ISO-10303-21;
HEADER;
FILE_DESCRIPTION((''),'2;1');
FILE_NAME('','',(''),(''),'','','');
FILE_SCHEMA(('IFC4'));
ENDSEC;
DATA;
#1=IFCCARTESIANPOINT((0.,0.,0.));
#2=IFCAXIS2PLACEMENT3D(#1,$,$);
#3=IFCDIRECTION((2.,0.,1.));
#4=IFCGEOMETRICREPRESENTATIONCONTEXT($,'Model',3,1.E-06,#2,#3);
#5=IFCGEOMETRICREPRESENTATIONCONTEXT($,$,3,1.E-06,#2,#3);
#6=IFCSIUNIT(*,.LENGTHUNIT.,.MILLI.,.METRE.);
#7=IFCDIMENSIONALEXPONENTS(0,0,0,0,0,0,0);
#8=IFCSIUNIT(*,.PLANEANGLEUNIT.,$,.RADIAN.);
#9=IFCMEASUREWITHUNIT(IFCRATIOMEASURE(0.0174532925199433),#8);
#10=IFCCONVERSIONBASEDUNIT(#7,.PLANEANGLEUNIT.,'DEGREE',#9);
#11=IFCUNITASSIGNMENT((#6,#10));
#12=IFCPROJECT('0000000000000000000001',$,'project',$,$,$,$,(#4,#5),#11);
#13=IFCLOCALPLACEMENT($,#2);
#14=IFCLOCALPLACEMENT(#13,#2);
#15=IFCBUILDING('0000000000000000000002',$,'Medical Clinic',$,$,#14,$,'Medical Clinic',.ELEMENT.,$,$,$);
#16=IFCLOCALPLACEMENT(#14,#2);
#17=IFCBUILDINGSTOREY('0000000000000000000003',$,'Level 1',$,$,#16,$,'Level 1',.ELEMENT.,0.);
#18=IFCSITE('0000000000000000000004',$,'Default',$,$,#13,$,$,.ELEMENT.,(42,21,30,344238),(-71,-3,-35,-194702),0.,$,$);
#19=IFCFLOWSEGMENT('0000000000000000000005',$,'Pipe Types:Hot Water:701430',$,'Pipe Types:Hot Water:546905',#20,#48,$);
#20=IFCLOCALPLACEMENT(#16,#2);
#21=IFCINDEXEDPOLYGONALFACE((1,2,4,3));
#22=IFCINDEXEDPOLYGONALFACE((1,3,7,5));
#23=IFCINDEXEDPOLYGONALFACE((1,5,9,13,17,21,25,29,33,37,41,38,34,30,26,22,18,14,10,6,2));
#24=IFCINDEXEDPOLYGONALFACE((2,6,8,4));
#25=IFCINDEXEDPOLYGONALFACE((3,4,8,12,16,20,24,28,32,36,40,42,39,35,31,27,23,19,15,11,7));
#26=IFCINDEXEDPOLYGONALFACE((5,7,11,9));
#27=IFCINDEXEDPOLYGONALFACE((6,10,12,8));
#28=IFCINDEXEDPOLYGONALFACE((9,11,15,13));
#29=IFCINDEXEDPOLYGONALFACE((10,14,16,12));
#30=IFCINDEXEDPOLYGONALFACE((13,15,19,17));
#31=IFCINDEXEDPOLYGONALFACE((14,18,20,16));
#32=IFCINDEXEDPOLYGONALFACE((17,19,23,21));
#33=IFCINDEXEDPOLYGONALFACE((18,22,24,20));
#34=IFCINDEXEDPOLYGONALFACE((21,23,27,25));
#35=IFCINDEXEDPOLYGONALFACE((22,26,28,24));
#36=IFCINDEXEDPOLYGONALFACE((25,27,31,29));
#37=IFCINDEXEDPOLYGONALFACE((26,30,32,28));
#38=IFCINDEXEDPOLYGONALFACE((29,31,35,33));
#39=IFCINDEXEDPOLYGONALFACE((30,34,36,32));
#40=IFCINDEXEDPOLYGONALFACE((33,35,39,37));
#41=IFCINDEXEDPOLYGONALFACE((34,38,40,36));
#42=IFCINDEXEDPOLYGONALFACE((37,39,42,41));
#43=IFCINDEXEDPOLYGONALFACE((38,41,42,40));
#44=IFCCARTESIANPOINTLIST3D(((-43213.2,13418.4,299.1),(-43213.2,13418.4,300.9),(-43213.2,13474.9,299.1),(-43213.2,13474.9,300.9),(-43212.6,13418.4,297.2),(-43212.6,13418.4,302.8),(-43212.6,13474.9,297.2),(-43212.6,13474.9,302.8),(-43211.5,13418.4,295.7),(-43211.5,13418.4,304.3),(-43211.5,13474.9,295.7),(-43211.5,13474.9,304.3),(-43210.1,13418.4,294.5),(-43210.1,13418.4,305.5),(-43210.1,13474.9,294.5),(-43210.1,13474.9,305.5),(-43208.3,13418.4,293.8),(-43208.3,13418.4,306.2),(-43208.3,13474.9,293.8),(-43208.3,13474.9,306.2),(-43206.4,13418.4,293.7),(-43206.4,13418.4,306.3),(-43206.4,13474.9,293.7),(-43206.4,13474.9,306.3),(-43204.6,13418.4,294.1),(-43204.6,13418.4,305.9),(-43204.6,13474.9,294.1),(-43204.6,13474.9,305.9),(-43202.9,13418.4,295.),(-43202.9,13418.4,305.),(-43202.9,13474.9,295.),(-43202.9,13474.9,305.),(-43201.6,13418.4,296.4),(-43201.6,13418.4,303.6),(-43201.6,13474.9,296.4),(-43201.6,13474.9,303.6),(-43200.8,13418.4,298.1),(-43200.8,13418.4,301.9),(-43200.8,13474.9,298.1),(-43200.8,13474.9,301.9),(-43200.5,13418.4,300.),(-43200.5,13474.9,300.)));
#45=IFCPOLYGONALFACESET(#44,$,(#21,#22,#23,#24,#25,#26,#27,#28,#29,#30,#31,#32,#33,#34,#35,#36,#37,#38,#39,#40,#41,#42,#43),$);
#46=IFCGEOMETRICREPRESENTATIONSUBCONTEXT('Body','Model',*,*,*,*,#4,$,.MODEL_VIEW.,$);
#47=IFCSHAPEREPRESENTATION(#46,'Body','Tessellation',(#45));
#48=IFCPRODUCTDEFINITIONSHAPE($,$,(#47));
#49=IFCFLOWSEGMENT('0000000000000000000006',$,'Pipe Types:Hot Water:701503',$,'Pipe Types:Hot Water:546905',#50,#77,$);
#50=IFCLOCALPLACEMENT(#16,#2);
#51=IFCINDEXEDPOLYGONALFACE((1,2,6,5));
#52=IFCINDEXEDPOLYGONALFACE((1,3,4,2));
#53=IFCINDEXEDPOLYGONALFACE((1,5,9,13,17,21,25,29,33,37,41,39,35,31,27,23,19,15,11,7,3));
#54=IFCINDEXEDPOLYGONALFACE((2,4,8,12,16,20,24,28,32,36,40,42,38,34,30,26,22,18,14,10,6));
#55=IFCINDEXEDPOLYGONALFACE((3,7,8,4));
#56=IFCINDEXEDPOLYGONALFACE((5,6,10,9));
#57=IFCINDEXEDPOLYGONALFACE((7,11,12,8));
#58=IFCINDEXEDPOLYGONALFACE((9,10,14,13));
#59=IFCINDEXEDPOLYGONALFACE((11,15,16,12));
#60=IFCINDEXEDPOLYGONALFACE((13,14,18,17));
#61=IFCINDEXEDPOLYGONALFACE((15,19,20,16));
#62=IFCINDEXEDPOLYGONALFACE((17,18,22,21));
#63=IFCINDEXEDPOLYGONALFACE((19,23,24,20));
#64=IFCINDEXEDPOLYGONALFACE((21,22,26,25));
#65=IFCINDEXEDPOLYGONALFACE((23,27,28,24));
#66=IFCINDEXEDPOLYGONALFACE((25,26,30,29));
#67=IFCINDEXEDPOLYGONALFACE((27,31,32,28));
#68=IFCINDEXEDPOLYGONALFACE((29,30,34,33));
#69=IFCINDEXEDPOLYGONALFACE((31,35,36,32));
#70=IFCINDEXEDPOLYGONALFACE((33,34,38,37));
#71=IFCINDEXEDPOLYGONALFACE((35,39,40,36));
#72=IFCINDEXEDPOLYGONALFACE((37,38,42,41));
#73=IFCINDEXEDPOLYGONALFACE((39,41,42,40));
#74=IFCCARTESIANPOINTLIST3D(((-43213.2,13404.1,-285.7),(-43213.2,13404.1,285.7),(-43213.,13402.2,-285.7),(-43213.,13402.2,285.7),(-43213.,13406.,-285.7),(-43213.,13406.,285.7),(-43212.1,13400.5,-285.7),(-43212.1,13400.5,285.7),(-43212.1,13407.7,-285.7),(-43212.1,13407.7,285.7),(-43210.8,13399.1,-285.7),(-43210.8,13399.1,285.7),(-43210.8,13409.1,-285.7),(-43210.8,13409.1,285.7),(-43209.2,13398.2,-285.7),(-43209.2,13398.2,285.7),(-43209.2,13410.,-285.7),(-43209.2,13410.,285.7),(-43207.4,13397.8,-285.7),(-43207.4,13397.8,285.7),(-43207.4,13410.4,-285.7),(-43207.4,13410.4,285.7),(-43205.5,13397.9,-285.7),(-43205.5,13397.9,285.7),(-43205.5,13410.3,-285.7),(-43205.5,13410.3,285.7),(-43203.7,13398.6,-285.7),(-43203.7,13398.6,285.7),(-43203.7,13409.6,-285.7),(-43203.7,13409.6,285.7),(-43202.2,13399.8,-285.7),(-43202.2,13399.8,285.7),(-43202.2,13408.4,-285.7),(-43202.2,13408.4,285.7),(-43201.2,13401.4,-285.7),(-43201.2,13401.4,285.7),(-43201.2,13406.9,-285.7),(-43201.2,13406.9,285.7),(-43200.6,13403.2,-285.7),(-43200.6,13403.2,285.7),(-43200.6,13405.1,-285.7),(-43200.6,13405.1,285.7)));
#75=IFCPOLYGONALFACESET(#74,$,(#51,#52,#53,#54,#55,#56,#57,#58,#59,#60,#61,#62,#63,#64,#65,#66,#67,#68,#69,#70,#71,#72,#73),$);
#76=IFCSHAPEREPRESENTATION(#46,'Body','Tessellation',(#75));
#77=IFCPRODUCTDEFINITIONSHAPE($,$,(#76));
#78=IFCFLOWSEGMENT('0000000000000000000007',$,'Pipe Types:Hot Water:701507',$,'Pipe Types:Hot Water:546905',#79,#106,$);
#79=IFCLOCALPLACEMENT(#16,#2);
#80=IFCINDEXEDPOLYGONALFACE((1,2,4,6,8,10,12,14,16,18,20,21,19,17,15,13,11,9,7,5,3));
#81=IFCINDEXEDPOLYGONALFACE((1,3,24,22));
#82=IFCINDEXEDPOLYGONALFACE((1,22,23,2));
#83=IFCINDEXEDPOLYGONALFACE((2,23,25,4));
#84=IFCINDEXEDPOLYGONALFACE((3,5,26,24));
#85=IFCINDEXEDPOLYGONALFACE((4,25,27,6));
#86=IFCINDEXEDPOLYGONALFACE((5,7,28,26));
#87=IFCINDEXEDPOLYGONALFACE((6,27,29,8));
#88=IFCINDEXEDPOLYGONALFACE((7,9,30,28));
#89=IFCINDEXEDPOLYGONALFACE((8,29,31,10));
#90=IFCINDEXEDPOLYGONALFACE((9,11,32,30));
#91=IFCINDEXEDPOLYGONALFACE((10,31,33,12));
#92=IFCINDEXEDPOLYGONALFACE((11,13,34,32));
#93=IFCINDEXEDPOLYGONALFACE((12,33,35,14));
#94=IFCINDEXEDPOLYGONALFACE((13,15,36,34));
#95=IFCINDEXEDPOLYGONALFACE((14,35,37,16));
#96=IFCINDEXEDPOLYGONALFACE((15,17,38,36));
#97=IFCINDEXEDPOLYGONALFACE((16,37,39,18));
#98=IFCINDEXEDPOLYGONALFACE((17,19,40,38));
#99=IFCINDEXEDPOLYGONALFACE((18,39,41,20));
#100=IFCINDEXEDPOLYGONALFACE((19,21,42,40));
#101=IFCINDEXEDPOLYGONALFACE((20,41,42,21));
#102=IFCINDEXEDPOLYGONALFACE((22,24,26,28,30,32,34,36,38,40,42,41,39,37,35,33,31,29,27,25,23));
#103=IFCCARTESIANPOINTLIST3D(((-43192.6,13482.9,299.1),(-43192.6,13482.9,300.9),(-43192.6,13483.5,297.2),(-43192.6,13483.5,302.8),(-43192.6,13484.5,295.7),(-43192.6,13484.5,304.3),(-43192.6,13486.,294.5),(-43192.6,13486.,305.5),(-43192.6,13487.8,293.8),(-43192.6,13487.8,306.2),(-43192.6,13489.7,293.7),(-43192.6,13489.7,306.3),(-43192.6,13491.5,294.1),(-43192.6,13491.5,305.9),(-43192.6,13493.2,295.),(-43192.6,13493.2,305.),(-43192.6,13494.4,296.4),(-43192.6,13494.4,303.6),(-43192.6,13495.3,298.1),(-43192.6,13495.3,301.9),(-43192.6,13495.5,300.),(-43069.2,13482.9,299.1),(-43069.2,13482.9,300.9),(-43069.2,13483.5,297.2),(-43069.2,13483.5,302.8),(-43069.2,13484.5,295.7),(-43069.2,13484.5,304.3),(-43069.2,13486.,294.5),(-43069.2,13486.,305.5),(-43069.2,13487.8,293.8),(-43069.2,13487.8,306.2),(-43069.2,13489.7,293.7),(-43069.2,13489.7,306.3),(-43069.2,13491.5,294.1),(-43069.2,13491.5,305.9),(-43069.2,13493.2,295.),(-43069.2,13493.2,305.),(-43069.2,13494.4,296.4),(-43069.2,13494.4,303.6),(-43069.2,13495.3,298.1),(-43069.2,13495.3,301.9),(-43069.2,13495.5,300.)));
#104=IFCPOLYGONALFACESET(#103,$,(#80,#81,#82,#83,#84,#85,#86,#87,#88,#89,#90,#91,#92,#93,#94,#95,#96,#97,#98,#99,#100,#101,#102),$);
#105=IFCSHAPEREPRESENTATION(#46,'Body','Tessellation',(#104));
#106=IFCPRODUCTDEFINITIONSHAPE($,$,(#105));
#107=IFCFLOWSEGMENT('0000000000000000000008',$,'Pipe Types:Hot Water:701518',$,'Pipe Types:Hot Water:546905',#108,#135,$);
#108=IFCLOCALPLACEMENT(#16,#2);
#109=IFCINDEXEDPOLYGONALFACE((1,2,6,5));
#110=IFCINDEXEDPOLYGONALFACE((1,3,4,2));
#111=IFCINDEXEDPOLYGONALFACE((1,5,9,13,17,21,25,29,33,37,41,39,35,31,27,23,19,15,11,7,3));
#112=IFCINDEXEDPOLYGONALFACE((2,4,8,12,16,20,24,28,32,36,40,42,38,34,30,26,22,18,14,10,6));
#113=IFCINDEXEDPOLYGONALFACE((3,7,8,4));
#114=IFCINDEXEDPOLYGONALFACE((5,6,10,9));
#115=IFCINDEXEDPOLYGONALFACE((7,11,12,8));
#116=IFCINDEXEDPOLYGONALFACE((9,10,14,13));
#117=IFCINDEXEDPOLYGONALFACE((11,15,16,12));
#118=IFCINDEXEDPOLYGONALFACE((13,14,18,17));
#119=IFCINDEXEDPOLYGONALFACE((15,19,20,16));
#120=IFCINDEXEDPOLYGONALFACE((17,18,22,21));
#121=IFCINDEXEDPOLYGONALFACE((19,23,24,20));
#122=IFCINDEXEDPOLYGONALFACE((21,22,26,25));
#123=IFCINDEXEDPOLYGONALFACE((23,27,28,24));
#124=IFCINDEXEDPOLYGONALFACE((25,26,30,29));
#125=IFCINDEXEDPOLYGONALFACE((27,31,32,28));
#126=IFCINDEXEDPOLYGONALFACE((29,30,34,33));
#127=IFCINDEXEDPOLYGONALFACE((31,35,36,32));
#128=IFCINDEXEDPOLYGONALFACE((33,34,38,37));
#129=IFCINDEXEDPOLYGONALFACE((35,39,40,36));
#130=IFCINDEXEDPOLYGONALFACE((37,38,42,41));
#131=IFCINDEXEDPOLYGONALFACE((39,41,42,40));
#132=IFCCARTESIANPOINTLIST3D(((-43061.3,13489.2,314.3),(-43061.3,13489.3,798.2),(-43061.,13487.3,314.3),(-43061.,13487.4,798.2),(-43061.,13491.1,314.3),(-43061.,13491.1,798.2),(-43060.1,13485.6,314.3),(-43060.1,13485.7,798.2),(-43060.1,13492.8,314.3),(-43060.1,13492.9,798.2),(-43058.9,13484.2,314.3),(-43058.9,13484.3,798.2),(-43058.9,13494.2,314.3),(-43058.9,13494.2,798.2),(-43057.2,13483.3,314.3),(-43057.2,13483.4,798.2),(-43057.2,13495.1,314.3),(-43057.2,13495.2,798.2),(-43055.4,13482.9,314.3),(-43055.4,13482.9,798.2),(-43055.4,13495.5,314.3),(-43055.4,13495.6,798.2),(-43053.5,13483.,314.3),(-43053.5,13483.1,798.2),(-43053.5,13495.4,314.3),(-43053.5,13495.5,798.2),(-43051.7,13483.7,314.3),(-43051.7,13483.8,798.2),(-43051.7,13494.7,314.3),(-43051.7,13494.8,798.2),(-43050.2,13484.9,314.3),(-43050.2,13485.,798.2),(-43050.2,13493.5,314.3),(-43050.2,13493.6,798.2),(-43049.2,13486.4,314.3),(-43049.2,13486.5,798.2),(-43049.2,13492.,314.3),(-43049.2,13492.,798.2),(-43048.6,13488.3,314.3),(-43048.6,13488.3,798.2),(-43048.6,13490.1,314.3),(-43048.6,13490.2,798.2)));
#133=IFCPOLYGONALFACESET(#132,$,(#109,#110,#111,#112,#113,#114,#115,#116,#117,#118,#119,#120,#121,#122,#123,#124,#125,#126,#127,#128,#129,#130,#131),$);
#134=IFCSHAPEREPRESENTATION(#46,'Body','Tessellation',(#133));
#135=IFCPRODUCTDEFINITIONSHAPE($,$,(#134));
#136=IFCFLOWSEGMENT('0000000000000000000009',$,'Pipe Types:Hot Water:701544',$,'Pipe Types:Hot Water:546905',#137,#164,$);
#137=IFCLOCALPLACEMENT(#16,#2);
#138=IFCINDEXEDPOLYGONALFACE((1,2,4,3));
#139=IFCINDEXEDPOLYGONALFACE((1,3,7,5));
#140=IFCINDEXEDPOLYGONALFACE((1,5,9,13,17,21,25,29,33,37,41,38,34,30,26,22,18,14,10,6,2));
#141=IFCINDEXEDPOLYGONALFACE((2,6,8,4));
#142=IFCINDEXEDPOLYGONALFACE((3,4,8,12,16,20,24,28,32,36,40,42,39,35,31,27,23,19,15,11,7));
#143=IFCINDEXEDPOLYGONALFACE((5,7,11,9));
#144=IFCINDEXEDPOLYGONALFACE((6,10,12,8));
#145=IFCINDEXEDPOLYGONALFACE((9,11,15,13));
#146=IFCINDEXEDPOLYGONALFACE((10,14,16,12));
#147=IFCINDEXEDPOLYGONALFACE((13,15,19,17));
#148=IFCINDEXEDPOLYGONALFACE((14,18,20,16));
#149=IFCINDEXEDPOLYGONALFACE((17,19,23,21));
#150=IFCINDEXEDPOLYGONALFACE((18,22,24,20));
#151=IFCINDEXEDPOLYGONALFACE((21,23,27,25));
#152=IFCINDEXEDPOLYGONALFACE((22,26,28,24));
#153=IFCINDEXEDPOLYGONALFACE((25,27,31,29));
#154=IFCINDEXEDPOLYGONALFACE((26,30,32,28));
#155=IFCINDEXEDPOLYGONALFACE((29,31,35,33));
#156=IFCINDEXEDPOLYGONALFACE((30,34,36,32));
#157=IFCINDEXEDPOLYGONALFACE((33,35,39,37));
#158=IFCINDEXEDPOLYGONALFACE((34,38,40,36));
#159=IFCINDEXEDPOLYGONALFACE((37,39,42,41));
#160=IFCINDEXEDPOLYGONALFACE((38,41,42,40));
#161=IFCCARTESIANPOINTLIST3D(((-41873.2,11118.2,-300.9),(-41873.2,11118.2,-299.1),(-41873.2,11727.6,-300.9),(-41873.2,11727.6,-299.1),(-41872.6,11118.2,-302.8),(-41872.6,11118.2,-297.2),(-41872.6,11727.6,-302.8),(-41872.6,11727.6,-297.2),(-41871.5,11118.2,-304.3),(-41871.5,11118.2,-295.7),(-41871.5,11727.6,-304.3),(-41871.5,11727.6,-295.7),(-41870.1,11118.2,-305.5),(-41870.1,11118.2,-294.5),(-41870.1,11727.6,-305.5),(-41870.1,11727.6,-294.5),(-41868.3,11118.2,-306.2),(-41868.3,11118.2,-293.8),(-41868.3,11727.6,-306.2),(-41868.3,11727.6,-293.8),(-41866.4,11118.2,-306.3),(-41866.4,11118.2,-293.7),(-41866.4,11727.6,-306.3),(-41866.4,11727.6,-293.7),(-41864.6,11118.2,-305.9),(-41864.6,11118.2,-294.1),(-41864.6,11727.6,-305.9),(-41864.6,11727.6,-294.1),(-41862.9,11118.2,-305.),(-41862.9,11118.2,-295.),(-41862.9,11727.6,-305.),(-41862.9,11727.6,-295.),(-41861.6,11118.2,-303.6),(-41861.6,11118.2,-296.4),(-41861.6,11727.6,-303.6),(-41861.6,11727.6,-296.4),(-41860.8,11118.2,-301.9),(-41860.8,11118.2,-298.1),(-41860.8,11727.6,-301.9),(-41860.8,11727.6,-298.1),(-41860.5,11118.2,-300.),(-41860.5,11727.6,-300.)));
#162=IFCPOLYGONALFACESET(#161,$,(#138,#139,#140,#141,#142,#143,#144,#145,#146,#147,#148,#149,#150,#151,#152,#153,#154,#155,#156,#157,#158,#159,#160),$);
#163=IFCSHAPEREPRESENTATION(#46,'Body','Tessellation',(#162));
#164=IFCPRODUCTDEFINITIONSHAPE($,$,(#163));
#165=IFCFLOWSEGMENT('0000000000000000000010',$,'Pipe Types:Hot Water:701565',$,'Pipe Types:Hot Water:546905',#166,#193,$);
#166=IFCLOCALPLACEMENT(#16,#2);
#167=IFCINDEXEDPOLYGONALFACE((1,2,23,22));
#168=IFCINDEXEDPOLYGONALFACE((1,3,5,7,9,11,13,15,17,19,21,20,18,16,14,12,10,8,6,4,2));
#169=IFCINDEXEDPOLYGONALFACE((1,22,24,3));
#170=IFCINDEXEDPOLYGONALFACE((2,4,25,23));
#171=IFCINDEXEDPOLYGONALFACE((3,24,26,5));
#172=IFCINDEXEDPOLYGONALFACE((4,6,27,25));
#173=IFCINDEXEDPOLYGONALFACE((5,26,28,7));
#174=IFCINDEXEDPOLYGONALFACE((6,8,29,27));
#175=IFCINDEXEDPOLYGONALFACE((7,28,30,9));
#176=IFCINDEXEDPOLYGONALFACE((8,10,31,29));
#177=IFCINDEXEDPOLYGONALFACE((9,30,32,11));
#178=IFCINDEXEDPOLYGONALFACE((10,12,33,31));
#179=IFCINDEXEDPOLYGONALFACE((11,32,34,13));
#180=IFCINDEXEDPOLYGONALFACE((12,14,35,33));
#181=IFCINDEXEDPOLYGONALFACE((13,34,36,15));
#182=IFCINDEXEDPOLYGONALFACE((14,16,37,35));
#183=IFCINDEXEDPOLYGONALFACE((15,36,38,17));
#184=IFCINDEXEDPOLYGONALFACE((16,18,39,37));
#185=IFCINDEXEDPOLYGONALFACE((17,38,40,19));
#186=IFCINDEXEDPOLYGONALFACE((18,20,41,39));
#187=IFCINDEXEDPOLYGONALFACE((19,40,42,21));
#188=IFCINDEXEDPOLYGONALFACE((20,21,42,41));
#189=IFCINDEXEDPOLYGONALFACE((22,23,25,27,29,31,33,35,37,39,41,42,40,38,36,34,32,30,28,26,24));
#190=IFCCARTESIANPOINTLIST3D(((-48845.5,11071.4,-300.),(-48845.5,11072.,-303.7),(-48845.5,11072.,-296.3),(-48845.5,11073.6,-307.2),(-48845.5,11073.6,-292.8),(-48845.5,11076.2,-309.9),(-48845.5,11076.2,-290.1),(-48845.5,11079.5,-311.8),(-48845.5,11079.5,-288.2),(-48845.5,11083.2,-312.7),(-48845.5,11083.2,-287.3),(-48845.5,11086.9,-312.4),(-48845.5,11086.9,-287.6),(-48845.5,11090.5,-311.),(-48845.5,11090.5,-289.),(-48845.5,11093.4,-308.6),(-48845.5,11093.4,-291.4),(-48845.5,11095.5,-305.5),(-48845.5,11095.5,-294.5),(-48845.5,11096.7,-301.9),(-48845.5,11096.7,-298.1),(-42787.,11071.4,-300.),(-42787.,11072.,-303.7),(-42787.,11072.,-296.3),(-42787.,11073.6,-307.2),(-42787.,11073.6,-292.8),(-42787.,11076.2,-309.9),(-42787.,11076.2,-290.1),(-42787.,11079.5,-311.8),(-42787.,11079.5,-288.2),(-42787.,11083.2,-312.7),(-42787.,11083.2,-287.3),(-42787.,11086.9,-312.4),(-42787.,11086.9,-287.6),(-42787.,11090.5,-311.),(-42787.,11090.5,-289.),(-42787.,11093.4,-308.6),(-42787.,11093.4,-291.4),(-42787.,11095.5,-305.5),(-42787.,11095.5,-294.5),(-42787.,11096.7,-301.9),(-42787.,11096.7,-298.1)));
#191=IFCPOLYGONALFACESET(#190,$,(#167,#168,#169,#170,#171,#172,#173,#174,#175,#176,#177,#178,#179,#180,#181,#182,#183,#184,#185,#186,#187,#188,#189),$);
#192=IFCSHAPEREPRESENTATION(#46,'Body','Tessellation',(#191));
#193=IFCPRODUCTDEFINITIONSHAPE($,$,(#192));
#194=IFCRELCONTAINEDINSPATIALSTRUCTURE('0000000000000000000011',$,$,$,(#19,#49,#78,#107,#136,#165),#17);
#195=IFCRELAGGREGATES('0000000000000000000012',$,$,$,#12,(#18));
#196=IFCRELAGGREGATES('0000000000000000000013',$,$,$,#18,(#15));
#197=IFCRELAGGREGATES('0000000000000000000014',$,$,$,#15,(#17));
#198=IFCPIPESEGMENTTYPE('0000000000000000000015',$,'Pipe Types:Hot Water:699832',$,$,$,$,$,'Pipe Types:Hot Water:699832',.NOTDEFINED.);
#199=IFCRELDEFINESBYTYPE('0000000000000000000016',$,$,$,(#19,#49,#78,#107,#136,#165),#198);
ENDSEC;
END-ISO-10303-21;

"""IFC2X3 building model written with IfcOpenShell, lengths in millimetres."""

from ifc_helpers import new_model, entity, si_unit, converted_unit, direction, frame, frame_2d, origin, origin_2d_with_axis, place, context, subcontext, project, spatial, circle, extrude, type_object, element, save


model = new_model("IFC2X3")

# Units and contexts
model_context = context("Model", 3, precision=1e-06, world=origin(), true_north=direction((2.0, 0.0, 1.0)))
context_of_model = context(None, 3, precision=1e-06, world=origin(), true_north=direction((2.0, 0.0, 1.0)))
body_context = subcontext(model_context, "Body", "Model", "MODEL_VIEW")
ifc_project = project(units=[si_unit("LENGTHUNIT", "METRE", prefix="MILLI"), converted_unit("PLANEANGLEUNIT", "DEGREE", entity("IfcRatioMeasure", 0.0174532925199433), si_unit("PLANEANGLEUNIT", "RADIAN"), dimensions=[0, 0, 0, 0, 0, 0, 0])], contexts=[model_context, context_of_model])

# Site, building, storey
site_placement = place(None, origin())
site = spatial("IfcSite", under=ifc_project, at=site_placement, Name="Default", CompositionType="ELEMENT", RefLatitude=(42, 21, 30, 344238), RefLongitude=(-71, -3, -35, -194702), RefElevation=0.0)
building_placement = place(site_placement, origin())
building = spatial("IfcBuilding", under=site, at=building_placement, Name="Medical Clinic", LongName="Medical Clinic", CompositionType="ELEMENT")
storey_placement = place(building_placement, origin())
storey = spatial("IfcBuildingStorey", under=building, at=storey_placement, Name="Level 1", LongName="Level 1", CompositionType="ELEMENT", Elevation=0.0)

# Flow segments
pipe_segment_type_1 = type_object("IfcPipeSegmentType", Name="Pipe Types:Hot Water:699832", ElementType="Pipe Types:Hot Water:699832", PredefinedType="NOTDEFINED")
flow_segment_1_placement = place(storey_placement, origin())
element("IfcFlowSegment", 1, at=flow_segment_1_placement, inside=storey, type_object=pipe_segment_type_1, Name="Pipe Types:Hot Water:701430", ObjectType="Pipe Types:Hot Water:546905", context=body_context, shape_type="SweptSolid", body=[
    extrude(circle(Radius=6.3, at=frame_2d((0.0, 0.0), x_axis=(1.0, 0.0))), frame((-43206.9, 13418.4, 300.0), z_axis=(0.0, 1.0, 0.0), x_axis=(1.0, 0.0, 0.0)), (0.0, 0.0, 1.0), 56.5),
])
flow_segment_2_placement = place(storey_placement, origin())
element("IfcFlowSegment", 2, at=flow_segment_2_placement, inside=storey, type_object=pipe_segment_type_1, Name="Pipe Types:Hot Water:701503", ObjectType="Pipe Types:Hot Water:546905", context=body_context, shape_type="SweptSolid", body=[
    extrude(circle(Radius=6.3, at=frame_2d((0.0, 0.0), x_axis=(1.0, 0.0))), frame((-43206.9, 13404.1, -285.7), z_axis=(0.0, 0.0, 1.0), x_axis=(-1.0, 0.0, 0.0)), (0.0, 0.0, 1.0), 571.4),
])
flow_segment_3_placement = place(storey_placement, origin())
element("IfcFlowSegment", 3, at=flow_segment_3_placement, inside=storey, type_object=pipe_segment_type_1, Name="Pipe Types:Hot Water:701507", ObjectType="Pipe Types:Hot Water:546905", context=body_context, shape_type="SweptSolid", body=[
    extrude(circle(Radius=6.3, at=frame_2d((0.0, 0.0), x_axis=(1.0, 0.0))), frame((-43192.6, 13489.2, 300.0), z_axis=(1.0, 0.0, 0.0), x_axis=(0.0, 1.0, 0.0)), (0.0, 0.0, 1.0), 123.4),
])
flow_segment_4_placement = place(storey_placement, origin())
element("IfcFlowSegment", 4, at=flow_segment_4_placement, inside=storey, type_object=pipe_segment_type_1, Name="Pipe Types:Hot Water:701518", ObjectType="Pipe Types:Hot Water:546905", context=body_context, shape_type="SweptSolid", body=[
    extrude(circle(Radius=6.3, at=frame_2d((0.0, 0.0), x_axis=(1.0, 0.0))), frame((-43054.9, 13489.2, 314.3), z_axis=(0.0, 0.000151, 1.0), x_axis=(-1.0, 0.0, 0.0)), (0.0, 0.0, 1.0), 483.9),
])
flow_segment_5_placement = place(storey_placement, origin())
element("IfcFlowSegment", 5, at=flow_segment_5_placement, inside=storey, type_object=pipe_segment_type_1, Name="Pipe Types:Hot Water:701544", ObjectType="Pipe Types:Hot Water:546905", context=body_context, shape_type="SweptSolid", body=[
    extrude(circle(Radius=6.3, at=origin_2d_with_axis()), frame((-41866.9, 11118.2, -300.0), z_axis=(0.0, 1.0, 0.0), x_axis=(1.0, 0.0, 0.0)), (0.0, 0.0, 1.0), 609.4),
])
flow_segment_6_placement = place(storey_placement, origin())
element("IfcFlowSegment", 6, at=flow_segment_6_placement, inside=storey, type_object=pipe_segment_type_1, Name="Pipe Types:Hot Water:701565", ObjectType="Pipe Types:Hot Water:546905", context=body_context, shape_type="SweptSolid", body=[
    extrude(circle(Radius=12.7, at=origin_2d_with_axis()), frame((-48845.5, 11084.1, -300.0), z_axis=(1.0, 0.0, 0.0), x_axis=(0.0, -1.0, 0.0)), (0.0, 0.0, 1.0), 6058.5),
])

save(model, "model.ifc")
